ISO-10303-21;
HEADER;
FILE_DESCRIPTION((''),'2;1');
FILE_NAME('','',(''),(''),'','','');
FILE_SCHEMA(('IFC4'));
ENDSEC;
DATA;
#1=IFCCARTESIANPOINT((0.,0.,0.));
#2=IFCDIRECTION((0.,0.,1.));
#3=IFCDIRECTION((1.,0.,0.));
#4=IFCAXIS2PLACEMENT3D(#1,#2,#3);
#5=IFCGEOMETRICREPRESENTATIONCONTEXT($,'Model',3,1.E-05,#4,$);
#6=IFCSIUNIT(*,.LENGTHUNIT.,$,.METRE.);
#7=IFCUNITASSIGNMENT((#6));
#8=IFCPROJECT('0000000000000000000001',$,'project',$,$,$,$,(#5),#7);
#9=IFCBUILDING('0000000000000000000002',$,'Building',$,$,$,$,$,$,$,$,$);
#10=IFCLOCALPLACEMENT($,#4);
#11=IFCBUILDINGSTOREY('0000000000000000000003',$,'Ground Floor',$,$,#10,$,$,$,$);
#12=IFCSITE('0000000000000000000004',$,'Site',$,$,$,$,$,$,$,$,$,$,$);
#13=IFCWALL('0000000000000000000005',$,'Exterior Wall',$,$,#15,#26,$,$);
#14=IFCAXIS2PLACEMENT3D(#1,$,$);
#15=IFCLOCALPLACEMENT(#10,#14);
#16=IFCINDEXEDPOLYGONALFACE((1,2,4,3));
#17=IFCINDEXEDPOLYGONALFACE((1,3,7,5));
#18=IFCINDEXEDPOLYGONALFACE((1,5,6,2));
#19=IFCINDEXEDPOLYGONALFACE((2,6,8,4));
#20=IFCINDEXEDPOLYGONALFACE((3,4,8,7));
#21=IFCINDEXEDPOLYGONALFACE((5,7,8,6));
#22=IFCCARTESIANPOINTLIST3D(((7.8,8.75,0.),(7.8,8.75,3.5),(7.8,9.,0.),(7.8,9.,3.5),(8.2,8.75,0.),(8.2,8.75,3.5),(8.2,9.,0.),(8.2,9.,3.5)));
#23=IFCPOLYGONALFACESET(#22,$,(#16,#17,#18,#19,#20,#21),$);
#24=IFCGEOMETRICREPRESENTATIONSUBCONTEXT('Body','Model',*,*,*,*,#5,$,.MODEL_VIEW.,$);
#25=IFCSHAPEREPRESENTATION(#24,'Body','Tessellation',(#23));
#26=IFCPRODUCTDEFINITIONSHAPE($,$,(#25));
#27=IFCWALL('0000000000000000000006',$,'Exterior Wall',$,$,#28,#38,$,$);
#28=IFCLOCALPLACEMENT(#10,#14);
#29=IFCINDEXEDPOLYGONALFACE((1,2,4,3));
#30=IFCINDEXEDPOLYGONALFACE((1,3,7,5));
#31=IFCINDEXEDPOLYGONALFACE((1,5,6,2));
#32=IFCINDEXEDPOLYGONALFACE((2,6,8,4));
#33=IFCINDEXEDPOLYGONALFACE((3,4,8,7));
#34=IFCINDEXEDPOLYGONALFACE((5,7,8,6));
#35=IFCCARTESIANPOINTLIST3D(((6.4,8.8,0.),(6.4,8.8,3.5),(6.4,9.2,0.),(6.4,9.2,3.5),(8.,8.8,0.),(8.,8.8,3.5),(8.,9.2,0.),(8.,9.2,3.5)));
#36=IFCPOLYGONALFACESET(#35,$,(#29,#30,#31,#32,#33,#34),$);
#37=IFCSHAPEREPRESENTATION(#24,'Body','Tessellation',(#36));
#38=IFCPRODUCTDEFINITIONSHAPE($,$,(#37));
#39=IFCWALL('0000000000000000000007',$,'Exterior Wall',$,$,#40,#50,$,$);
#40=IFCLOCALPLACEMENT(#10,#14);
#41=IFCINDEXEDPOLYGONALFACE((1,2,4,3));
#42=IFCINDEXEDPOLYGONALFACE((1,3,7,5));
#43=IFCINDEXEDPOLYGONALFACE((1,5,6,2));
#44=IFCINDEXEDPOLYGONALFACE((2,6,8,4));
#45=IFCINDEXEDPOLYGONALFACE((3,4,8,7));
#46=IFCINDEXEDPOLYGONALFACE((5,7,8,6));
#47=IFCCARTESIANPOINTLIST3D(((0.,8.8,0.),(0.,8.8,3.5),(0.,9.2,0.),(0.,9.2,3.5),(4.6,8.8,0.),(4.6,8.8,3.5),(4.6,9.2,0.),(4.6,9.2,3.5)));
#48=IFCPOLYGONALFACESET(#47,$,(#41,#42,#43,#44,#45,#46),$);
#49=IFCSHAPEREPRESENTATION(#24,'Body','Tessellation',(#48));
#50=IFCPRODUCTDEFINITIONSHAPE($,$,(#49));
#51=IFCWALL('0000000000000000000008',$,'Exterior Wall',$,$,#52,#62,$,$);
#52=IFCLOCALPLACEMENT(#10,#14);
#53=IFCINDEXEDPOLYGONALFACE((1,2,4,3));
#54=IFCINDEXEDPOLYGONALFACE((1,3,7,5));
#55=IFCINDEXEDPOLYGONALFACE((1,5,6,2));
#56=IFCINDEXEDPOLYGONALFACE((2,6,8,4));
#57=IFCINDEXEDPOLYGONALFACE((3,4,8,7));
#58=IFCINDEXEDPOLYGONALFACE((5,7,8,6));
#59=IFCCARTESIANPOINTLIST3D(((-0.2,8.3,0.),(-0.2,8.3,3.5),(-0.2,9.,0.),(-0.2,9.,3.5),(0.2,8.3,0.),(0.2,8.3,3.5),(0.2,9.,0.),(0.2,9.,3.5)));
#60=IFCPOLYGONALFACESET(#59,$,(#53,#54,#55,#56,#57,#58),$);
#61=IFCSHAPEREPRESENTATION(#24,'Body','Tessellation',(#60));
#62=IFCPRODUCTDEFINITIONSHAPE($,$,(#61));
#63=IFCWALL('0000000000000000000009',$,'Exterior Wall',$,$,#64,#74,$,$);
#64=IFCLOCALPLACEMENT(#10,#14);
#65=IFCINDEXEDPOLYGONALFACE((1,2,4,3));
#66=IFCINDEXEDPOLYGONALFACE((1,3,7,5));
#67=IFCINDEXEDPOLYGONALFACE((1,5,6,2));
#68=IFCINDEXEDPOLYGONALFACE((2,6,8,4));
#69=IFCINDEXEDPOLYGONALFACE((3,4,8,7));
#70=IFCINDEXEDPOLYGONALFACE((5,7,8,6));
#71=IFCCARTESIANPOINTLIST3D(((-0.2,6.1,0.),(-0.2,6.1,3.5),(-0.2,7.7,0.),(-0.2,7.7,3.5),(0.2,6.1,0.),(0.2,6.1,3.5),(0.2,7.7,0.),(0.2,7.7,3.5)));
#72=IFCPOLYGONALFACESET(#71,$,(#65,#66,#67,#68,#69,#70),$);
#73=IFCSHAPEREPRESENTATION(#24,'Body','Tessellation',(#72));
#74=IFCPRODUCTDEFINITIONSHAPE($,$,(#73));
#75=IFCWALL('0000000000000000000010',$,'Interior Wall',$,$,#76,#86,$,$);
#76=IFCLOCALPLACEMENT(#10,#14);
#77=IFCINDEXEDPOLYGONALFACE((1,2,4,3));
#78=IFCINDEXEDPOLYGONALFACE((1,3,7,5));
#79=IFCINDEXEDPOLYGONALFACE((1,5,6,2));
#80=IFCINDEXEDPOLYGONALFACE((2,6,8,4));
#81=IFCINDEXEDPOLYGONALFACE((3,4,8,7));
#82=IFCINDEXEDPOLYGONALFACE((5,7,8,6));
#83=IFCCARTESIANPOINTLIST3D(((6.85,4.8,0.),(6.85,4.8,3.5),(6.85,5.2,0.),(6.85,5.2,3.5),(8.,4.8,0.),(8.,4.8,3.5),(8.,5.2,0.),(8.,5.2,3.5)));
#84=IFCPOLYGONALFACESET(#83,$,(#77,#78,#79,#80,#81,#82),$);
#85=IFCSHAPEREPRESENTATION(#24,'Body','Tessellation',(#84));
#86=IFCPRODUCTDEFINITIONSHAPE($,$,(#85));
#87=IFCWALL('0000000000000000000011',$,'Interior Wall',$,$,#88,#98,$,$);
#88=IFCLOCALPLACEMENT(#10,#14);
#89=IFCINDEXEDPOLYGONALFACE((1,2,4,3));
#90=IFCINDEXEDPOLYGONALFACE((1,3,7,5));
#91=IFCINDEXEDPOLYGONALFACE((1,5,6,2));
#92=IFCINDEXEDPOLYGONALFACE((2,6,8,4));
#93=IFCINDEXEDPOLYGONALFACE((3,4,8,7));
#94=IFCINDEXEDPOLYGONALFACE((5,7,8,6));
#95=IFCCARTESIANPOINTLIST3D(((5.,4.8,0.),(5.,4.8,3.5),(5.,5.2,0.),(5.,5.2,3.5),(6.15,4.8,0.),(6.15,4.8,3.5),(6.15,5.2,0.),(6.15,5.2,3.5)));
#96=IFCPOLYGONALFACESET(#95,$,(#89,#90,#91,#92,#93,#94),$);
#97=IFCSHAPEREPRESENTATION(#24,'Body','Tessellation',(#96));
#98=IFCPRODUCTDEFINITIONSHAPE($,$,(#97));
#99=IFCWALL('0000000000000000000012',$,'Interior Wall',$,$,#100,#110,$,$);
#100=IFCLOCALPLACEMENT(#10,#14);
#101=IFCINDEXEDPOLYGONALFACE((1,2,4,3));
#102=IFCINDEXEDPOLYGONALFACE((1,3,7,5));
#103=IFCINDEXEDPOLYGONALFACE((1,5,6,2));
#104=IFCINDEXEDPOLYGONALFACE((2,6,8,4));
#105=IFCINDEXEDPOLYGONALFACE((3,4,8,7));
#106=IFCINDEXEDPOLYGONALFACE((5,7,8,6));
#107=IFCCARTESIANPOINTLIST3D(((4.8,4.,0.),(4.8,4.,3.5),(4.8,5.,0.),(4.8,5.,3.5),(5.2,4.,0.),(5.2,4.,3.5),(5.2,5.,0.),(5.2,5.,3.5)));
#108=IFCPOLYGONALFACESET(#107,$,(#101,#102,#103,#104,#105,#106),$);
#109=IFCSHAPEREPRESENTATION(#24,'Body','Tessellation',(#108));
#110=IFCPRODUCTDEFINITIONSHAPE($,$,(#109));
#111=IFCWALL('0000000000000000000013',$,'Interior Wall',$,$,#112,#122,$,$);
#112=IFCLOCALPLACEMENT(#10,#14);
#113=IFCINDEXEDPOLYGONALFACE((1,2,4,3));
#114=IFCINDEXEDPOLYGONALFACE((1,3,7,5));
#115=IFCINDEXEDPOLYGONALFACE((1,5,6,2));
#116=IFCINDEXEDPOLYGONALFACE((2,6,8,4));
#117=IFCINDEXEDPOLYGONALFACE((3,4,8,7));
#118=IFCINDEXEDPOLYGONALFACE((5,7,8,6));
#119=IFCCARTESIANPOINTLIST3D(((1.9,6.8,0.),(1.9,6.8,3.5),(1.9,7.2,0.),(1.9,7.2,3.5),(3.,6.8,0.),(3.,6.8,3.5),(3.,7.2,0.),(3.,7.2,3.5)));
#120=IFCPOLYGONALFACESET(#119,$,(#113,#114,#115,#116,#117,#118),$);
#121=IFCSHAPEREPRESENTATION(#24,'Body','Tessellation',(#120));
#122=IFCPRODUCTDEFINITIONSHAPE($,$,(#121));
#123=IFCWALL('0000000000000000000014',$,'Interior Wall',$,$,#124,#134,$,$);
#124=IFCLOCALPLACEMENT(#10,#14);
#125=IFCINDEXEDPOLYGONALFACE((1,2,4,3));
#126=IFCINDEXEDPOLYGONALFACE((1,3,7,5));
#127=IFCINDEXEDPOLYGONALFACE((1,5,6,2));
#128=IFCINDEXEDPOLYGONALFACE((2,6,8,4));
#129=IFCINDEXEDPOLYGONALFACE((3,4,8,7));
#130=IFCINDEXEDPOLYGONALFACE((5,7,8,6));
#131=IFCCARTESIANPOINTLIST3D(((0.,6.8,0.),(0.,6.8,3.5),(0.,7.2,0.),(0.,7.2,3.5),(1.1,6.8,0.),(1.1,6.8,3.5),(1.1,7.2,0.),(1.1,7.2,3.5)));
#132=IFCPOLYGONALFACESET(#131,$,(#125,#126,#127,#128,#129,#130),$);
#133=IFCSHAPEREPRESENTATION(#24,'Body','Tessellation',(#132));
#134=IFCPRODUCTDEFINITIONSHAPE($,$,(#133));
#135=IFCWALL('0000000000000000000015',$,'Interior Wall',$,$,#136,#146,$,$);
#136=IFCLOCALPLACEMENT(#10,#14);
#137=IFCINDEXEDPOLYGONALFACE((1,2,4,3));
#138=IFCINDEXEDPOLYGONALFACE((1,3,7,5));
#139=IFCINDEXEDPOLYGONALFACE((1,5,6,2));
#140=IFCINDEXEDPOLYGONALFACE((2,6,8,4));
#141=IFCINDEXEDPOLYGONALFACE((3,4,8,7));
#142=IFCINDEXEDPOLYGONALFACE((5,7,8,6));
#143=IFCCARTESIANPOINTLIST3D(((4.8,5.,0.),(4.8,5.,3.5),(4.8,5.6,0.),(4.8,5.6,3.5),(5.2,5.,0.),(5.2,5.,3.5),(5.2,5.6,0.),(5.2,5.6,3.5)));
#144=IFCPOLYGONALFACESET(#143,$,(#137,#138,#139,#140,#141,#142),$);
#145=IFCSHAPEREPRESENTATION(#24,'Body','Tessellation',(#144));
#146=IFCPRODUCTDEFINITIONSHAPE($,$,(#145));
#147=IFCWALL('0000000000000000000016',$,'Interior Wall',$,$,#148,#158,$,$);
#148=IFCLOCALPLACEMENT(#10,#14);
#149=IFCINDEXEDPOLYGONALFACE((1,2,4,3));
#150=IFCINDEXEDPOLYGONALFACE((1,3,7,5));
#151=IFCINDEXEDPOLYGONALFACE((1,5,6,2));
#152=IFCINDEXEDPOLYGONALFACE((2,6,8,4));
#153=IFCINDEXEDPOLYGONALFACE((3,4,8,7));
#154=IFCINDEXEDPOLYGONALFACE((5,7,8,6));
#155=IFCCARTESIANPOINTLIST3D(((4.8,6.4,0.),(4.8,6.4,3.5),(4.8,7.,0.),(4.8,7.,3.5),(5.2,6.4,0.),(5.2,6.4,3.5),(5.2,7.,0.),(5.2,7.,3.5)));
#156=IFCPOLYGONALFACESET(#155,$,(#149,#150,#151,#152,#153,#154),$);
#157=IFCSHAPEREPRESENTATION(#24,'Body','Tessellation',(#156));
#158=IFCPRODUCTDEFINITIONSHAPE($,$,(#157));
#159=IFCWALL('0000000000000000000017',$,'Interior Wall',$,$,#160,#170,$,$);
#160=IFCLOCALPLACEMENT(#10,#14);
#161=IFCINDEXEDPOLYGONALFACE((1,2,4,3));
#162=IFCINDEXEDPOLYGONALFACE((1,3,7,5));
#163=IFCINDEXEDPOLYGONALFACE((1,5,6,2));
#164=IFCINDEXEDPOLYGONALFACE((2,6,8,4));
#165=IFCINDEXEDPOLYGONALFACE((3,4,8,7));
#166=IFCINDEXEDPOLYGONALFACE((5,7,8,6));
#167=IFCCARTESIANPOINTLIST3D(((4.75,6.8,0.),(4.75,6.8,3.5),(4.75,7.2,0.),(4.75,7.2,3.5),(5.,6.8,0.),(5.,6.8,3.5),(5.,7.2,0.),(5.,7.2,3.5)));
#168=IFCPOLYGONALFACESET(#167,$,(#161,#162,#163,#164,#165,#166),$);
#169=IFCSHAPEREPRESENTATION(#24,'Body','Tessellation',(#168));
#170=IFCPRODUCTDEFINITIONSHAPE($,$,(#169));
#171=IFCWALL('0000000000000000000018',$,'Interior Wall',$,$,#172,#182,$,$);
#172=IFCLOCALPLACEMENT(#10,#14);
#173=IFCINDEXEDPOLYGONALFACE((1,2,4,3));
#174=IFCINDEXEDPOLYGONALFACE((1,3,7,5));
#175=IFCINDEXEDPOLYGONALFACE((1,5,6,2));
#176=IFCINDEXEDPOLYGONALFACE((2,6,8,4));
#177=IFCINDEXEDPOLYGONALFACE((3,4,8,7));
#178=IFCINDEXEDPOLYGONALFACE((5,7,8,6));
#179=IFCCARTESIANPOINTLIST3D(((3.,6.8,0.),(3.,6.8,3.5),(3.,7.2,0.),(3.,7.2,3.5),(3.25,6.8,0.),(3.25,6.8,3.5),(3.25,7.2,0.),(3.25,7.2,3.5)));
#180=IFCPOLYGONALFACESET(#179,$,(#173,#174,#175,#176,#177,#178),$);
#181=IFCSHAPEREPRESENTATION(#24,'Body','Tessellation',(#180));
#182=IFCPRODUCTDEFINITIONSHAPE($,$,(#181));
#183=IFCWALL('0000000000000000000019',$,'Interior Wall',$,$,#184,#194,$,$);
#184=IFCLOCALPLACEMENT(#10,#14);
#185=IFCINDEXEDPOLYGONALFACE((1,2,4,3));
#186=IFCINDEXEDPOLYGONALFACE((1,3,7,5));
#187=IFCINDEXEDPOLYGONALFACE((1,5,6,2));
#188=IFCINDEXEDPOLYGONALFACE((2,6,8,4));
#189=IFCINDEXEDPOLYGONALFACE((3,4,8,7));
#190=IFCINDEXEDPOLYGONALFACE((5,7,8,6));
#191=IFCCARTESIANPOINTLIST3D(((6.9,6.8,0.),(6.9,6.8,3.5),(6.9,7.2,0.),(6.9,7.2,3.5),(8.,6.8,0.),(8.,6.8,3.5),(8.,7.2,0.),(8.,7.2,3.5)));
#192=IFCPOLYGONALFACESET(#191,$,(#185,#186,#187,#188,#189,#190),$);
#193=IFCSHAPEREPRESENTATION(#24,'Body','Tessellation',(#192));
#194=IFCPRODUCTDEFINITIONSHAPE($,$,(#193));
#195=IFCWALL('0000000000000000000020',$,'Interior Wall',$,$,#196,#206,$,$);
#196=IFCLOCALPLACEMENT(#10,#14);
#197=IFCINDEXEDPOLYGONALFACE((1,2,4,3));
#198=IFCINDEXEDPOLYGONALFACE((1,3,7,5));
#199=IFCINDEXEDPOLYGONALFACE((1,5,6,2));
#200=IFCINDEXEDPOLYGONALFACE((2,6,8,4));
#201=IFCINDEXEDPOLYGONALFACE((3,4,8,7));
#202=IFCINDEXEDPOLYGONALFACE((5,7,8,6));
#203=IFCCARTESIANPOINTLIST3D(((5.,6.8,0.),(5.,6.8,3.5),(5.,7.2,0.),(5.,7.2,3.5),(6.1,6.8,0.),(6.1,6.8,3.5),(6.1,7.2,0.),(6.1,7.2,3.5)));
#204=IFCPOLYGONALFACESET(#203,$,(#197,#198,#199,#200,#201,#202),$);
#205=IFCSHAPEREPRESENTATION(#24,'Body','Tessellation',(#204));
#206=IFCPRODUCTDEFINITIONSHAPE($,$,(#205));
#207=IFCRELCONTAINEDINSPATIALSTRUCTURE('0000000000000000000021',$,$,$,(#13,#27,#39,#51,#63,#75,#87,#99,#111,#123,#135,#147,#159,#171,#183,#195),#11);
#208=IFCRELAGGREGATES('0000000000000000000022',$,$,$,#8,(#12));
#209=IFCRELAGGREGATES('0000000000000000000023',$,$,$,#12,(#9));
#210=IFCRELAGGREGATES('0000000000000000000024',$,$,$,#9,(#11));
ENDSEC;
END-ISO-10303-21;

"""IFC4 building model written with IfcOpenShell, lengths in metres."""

from ifc_helpers import new_model, si_unit, frame, origin_with_axes, place, context, subcontext, project, spatial, indexed_curve, outline, extrude, element, save


model = new_model("IFC4")

# Units and contexts
model_context = context("Model", 3, precision=1e-05, world=origin_with_axes())
body_context = subcontext(model_context, "Body", "Model", "MODEL_VIEW")
ifc_project = project(units=[si_unit("LENGTHUNIT", "METRE")], contexts=[model_context])

# Site, building, storey
site = spatial("IfcSite", under=ifc_project, Name="Site")
building = spatial("IfcBuilding", under=site, Name="Building")
storey_placement = place(None, origin_with_axes())
storey = spatial("IfcBuildingStorey", under=building, at=storey_placement, Name="Ground Floor")

# Walls
wall_1_placement = place(storey_placement, frame((8.0, 8.75, 0.0), z_axis=(0.0, 0.0, 1.0), x_axis=(0.0, 1.0, 0.0)))
element("IfcWall", 1, at=wall_1_placement, inside=storey, Name="Exterior Wall", context=body_context, shape_type="SweptSolid", body=[
    extrude(outline(indexed_curve([(0.0, 0.0), (0.0, 0.4), (0.25, 0.4), (0.25, 0.0), (0.0, 0.0)], self_intersect=False)), frame((0.0, -0.2, 0.0), z_axis=(0.0, 0.0, 1.0), x_axis=(1.0, 0.0, 0.0)), (0.0, 0.0, 1.0), 3.5),
])
wall_2_placement = place(storey_placement, frame((8.0, 9.0, 0.0), z_axis=(0.0, 0.0, 1.0), x_axis=(-1.0, 0.0, 0.0)))
element("IfcWall", 2, at=wall_2_placement, inside=storey, Name="Exterior Wall", context=body_context, shape_type="SweptSolid", body=[
    extrude(outline(indexed_curve([(0.0, 0.0), (0.0, 0.4), (1.6, 0.4), (1.6, 0.0), (0.0, 0.0)], self_intersect=False)), frame((0.0, -0.2, 0.0), z_axis=(0.0, 0.0, 1.0), x_axis=(1.0, 0.0, 0.0)), (0.0, 0.0, 1.0), 3.5),
])
wall_3_placement = place(storey_placement, frame((4.6, 9.0, 0.0), z_axis=(0.0, 0.0, 1.0), x_axis=(-1.0, 0.0, 0.0)))
element("IfcWall", 3, at=wall_3_placement, inside=storey, Name="Exterior Wall", context=body_context, shape_type="SweptSolid", body=[
    extrude(outline(indexed_curve([(0.0, 0.0), (0.0, 0.4), (4.6, 0.4), (4.6, 0.0), (0.0, 0.0)], self_intersect=False)), frame((0.0, -0.2, 0.0), z_axis=(0.0, 0.0, 1.0), x_axis=(1.0, 0.0, 0.0)), (0.0, 0.0, 1.0), 3.5),
])
wall_4_placement = place(storey_placement, frame((0.0, 9.0, 0.0), z_axis=(0.0, 0.0, 1.0), x_axis=(0.0, -1.0, 0.0)))
element("IfcWall", 4, at=wall_4_placement, inside=storey, Name="Exterior Wall", context=body_context, shape_type="SweptSolid", body=[
    extrude(outline(indexed_curve([(0.0, 0.0), (0.0, 0.4), (0.7, 0.4), (0.7, 0.0), (0.0, 0.0)], self_intersect=False)), frame((0.0, -0.2, 0.0), z_axis=(0.0, 0.0, 1.0), x_axis=(1.0, 0.0, 0.0)), (0.0, 0.0, 1.0), 3.5),
])
wall_5_placement = place(storey_placement, frame((0.0, 7.7, 0.0), z_axis=(0.0, 0.0, 1.0), x_axis=(0.0, -1.0, 0.0)))
element("IfcWall", 5, at=wall_5_placement, inside=storey, Name="Exterior Wall", context=body_context, shape_type="SweptSolid", body=[
    extrude(outline(indexed_curve([(0.0, 0.0), (0.0, 0.4), (1.6, 0.4), (1.6, 0.0), (0.0, 0.0)], self_intersect=False)), frame((0.0, -0.2, 0.0), z_axis=(0.0, 0.0, 1.0), x_axis=(1.0, 0.0, 0.0)), (0.0, 0.0, 1.0), 3.5),
])
for number, where, z_axis, x_axis, name in (
    (6, (8.0, 5.0, 0.0), (0.0, 0.0, 1.0), (-1.0, 0.0, 0.0), "Interior Wall"),
    (7, (6.15, 5.0, 0.0), (0.0, 0.0, 1.0), (-1.0, 0.0, 0.0), "Interior Wall"),
):
    element("IfcWall", number, at=place(storey_placement, frame(where, z_axis=z_axis, x_axis=x_axis)), inside=storey, Name=name, context=body_context, shape_type="SweptSolid", body=[
        extrude(outline(indexed_curve([(0.0, 0.0), (0.0, 0.4), (1.15, 0.4), (1.15, 0.0), (0.0, 0.0)], self_intersect=False)), frame((0.0, -0.2, 0.0), z_axis=(0.0, 0.0, 1.0), x_axis=(1.0, 0.0, 0.0)), (0.0, 0.0, 1.0), 3.5),
    ])
wall_6_placement = place(storey_placement, frame((5.0, 5.0, 0.0), z_axis=(0.0, 0.0, 1.0), x_axis=(0.0, -1.0, 0.0)))
element("IfcWall", 8, at=wall_6_placement, inside=storey, Name="Interior Wall", context=body_context, shape_type="SweptSolid", body=[
    extrude(outline(indexed_curve([(0.0, 0.0), (0.0, 0.4), (1.0, 0.4), (1.0, 0.0), (0.0, 0.0)], self_intersect=False)), frame((0.0, -0.2, 0.0), z_axis=(0.0, 0.0, 1.0), x_axis=(1.0, 0.0, 0.0)), (0.0, 0.0, 1.0), 3.5),
])
for number, where, z_axis, x_axis, name in (
    (9, (3.0, 7.0, 0.0), (0.0, 0.0, 1.0), (-1.0, 0.0, 0.0), "Interior Wall"),
    (10, (1.1, 7.0, 0.0), (0.0, 0.0, 1.0), (-1.0, 0.0, 0.0), "Interior Wall"),
):
    element("IfcWall", number, at=place(storey_placement, frame(where, z_axis=z_axis, x_axis=x_axis)), inside=storey, Name=name, context=body_context, shape_type="SweptSolid", body=[
        extrude(outline(indexed_curve([(0.0, 0.0), (0.0, 0.4), (1.1, 0.4), (1.1, 0.0), (0.0, 0.0)], self_intersect=False)), frame((0.0, -0.2, 0.0), z_axis=(0.0, 0.0, 1.0), x_axis=(1.0, 0.0, 0.0)), (0.0, 0.0, 1.0), 3.5),
    ])
for number, where, z_axis, x_axis, name in (
    (11, (5.0, 5.0, 0.0), (0.0, 0.0, 1.0), (0.0, 1.0, 0.0), "Interior Wall"),
    (12, (5.0, 6.4, 0.0), (0.0, 0.0, 1.0), (0.0, 1.0, 0.0), "Interior Wall"),
):
    element("IfcWall", number, at=place(storey_placement, frame(where, z_axis=z_axis, x_axis=x_axis)), inside=storey, Name=name, context=body_context, shape_type="SweptSolid", body=[
        extrude(outline(indexed_curve([(0.0, 0.0), (0.0, 0.4), (0.6, 0.4), (0.6, 0.0), (0.0, 0.0)], self_intersect=False)), frame((0.0, -0.2, 0.0), z_axis=(0.0, 0.0, 1.0), x_axis=(1.0, 0.0, 0.0)), (0.0, 0.0, 1.0), 3.5),
    ])
for number, where, z_axis, x_axis, name in (
    (13, (5.0, 7.0, 0.0), (0.0, 0.0, 1.0), (-1.0, 0.0, 0.0), "Interior Wall"),
    (14, (3.25, 7.0, 0.0), (0.0, 0.0, 1.0), (-1.0, 0.0, 0.0), "Interior Wall"),
):
    element("IfcWall", number, at=place(storey_placement, frame(where, z_axis=z_axis, x_axis=x_axis)), inside=storey, Name=name, context=body_context, shape_type="SweptSolid", body=[
        extrude(outline(indexed_curve([(0.0, 0.0), (0.0, 0.4), (0.25, 0.4), (0.25, 0.0), (0.0, 0.0)], self_intersect=False)), frame((0.0, -0.2, 0.0), z_axis=(0.0, 0.0, 1.0), x_axis=(1.0, 0.0, 0.0)), (0.0, 0.0, 1.0), 3.5),
    ])
for number, where, z_axis, x_axis, name in (
    (15, (8.0, 7.0, 0.0), (0.0, 0.0, 1.0), (-1.0, 0.0, 0.0), "Interior Wall"),
    (16, (6.1, 7.0, 0.0), (0.0, 0.0, 1.0), (-1.0, 0.0, 0.0), "Interior Wall"),
):
    element("IfcWall", number, at=place(storey_placement, frame(where, z_axis=z_axis, x_axis=x_axis)), inside=storey, Name=name, context=body_context, shape_type="SweptSolid", body=[
        extrude(outline(indexed_curve([(0.0, 0.0), (0.0, 0.4), (1.1, 0.4), (1.1, 0.0), (0.0, 0.0)], self_intersect=False)), frame((0.0, -0.2, 0.0), z_axis=(0.0, 0.0, 1.0), x_axis=(1.0, 0.0, 0.0)), (0.0, 0.0, 1.0), 3.5),
    ])

save(model, "model.ifc")
